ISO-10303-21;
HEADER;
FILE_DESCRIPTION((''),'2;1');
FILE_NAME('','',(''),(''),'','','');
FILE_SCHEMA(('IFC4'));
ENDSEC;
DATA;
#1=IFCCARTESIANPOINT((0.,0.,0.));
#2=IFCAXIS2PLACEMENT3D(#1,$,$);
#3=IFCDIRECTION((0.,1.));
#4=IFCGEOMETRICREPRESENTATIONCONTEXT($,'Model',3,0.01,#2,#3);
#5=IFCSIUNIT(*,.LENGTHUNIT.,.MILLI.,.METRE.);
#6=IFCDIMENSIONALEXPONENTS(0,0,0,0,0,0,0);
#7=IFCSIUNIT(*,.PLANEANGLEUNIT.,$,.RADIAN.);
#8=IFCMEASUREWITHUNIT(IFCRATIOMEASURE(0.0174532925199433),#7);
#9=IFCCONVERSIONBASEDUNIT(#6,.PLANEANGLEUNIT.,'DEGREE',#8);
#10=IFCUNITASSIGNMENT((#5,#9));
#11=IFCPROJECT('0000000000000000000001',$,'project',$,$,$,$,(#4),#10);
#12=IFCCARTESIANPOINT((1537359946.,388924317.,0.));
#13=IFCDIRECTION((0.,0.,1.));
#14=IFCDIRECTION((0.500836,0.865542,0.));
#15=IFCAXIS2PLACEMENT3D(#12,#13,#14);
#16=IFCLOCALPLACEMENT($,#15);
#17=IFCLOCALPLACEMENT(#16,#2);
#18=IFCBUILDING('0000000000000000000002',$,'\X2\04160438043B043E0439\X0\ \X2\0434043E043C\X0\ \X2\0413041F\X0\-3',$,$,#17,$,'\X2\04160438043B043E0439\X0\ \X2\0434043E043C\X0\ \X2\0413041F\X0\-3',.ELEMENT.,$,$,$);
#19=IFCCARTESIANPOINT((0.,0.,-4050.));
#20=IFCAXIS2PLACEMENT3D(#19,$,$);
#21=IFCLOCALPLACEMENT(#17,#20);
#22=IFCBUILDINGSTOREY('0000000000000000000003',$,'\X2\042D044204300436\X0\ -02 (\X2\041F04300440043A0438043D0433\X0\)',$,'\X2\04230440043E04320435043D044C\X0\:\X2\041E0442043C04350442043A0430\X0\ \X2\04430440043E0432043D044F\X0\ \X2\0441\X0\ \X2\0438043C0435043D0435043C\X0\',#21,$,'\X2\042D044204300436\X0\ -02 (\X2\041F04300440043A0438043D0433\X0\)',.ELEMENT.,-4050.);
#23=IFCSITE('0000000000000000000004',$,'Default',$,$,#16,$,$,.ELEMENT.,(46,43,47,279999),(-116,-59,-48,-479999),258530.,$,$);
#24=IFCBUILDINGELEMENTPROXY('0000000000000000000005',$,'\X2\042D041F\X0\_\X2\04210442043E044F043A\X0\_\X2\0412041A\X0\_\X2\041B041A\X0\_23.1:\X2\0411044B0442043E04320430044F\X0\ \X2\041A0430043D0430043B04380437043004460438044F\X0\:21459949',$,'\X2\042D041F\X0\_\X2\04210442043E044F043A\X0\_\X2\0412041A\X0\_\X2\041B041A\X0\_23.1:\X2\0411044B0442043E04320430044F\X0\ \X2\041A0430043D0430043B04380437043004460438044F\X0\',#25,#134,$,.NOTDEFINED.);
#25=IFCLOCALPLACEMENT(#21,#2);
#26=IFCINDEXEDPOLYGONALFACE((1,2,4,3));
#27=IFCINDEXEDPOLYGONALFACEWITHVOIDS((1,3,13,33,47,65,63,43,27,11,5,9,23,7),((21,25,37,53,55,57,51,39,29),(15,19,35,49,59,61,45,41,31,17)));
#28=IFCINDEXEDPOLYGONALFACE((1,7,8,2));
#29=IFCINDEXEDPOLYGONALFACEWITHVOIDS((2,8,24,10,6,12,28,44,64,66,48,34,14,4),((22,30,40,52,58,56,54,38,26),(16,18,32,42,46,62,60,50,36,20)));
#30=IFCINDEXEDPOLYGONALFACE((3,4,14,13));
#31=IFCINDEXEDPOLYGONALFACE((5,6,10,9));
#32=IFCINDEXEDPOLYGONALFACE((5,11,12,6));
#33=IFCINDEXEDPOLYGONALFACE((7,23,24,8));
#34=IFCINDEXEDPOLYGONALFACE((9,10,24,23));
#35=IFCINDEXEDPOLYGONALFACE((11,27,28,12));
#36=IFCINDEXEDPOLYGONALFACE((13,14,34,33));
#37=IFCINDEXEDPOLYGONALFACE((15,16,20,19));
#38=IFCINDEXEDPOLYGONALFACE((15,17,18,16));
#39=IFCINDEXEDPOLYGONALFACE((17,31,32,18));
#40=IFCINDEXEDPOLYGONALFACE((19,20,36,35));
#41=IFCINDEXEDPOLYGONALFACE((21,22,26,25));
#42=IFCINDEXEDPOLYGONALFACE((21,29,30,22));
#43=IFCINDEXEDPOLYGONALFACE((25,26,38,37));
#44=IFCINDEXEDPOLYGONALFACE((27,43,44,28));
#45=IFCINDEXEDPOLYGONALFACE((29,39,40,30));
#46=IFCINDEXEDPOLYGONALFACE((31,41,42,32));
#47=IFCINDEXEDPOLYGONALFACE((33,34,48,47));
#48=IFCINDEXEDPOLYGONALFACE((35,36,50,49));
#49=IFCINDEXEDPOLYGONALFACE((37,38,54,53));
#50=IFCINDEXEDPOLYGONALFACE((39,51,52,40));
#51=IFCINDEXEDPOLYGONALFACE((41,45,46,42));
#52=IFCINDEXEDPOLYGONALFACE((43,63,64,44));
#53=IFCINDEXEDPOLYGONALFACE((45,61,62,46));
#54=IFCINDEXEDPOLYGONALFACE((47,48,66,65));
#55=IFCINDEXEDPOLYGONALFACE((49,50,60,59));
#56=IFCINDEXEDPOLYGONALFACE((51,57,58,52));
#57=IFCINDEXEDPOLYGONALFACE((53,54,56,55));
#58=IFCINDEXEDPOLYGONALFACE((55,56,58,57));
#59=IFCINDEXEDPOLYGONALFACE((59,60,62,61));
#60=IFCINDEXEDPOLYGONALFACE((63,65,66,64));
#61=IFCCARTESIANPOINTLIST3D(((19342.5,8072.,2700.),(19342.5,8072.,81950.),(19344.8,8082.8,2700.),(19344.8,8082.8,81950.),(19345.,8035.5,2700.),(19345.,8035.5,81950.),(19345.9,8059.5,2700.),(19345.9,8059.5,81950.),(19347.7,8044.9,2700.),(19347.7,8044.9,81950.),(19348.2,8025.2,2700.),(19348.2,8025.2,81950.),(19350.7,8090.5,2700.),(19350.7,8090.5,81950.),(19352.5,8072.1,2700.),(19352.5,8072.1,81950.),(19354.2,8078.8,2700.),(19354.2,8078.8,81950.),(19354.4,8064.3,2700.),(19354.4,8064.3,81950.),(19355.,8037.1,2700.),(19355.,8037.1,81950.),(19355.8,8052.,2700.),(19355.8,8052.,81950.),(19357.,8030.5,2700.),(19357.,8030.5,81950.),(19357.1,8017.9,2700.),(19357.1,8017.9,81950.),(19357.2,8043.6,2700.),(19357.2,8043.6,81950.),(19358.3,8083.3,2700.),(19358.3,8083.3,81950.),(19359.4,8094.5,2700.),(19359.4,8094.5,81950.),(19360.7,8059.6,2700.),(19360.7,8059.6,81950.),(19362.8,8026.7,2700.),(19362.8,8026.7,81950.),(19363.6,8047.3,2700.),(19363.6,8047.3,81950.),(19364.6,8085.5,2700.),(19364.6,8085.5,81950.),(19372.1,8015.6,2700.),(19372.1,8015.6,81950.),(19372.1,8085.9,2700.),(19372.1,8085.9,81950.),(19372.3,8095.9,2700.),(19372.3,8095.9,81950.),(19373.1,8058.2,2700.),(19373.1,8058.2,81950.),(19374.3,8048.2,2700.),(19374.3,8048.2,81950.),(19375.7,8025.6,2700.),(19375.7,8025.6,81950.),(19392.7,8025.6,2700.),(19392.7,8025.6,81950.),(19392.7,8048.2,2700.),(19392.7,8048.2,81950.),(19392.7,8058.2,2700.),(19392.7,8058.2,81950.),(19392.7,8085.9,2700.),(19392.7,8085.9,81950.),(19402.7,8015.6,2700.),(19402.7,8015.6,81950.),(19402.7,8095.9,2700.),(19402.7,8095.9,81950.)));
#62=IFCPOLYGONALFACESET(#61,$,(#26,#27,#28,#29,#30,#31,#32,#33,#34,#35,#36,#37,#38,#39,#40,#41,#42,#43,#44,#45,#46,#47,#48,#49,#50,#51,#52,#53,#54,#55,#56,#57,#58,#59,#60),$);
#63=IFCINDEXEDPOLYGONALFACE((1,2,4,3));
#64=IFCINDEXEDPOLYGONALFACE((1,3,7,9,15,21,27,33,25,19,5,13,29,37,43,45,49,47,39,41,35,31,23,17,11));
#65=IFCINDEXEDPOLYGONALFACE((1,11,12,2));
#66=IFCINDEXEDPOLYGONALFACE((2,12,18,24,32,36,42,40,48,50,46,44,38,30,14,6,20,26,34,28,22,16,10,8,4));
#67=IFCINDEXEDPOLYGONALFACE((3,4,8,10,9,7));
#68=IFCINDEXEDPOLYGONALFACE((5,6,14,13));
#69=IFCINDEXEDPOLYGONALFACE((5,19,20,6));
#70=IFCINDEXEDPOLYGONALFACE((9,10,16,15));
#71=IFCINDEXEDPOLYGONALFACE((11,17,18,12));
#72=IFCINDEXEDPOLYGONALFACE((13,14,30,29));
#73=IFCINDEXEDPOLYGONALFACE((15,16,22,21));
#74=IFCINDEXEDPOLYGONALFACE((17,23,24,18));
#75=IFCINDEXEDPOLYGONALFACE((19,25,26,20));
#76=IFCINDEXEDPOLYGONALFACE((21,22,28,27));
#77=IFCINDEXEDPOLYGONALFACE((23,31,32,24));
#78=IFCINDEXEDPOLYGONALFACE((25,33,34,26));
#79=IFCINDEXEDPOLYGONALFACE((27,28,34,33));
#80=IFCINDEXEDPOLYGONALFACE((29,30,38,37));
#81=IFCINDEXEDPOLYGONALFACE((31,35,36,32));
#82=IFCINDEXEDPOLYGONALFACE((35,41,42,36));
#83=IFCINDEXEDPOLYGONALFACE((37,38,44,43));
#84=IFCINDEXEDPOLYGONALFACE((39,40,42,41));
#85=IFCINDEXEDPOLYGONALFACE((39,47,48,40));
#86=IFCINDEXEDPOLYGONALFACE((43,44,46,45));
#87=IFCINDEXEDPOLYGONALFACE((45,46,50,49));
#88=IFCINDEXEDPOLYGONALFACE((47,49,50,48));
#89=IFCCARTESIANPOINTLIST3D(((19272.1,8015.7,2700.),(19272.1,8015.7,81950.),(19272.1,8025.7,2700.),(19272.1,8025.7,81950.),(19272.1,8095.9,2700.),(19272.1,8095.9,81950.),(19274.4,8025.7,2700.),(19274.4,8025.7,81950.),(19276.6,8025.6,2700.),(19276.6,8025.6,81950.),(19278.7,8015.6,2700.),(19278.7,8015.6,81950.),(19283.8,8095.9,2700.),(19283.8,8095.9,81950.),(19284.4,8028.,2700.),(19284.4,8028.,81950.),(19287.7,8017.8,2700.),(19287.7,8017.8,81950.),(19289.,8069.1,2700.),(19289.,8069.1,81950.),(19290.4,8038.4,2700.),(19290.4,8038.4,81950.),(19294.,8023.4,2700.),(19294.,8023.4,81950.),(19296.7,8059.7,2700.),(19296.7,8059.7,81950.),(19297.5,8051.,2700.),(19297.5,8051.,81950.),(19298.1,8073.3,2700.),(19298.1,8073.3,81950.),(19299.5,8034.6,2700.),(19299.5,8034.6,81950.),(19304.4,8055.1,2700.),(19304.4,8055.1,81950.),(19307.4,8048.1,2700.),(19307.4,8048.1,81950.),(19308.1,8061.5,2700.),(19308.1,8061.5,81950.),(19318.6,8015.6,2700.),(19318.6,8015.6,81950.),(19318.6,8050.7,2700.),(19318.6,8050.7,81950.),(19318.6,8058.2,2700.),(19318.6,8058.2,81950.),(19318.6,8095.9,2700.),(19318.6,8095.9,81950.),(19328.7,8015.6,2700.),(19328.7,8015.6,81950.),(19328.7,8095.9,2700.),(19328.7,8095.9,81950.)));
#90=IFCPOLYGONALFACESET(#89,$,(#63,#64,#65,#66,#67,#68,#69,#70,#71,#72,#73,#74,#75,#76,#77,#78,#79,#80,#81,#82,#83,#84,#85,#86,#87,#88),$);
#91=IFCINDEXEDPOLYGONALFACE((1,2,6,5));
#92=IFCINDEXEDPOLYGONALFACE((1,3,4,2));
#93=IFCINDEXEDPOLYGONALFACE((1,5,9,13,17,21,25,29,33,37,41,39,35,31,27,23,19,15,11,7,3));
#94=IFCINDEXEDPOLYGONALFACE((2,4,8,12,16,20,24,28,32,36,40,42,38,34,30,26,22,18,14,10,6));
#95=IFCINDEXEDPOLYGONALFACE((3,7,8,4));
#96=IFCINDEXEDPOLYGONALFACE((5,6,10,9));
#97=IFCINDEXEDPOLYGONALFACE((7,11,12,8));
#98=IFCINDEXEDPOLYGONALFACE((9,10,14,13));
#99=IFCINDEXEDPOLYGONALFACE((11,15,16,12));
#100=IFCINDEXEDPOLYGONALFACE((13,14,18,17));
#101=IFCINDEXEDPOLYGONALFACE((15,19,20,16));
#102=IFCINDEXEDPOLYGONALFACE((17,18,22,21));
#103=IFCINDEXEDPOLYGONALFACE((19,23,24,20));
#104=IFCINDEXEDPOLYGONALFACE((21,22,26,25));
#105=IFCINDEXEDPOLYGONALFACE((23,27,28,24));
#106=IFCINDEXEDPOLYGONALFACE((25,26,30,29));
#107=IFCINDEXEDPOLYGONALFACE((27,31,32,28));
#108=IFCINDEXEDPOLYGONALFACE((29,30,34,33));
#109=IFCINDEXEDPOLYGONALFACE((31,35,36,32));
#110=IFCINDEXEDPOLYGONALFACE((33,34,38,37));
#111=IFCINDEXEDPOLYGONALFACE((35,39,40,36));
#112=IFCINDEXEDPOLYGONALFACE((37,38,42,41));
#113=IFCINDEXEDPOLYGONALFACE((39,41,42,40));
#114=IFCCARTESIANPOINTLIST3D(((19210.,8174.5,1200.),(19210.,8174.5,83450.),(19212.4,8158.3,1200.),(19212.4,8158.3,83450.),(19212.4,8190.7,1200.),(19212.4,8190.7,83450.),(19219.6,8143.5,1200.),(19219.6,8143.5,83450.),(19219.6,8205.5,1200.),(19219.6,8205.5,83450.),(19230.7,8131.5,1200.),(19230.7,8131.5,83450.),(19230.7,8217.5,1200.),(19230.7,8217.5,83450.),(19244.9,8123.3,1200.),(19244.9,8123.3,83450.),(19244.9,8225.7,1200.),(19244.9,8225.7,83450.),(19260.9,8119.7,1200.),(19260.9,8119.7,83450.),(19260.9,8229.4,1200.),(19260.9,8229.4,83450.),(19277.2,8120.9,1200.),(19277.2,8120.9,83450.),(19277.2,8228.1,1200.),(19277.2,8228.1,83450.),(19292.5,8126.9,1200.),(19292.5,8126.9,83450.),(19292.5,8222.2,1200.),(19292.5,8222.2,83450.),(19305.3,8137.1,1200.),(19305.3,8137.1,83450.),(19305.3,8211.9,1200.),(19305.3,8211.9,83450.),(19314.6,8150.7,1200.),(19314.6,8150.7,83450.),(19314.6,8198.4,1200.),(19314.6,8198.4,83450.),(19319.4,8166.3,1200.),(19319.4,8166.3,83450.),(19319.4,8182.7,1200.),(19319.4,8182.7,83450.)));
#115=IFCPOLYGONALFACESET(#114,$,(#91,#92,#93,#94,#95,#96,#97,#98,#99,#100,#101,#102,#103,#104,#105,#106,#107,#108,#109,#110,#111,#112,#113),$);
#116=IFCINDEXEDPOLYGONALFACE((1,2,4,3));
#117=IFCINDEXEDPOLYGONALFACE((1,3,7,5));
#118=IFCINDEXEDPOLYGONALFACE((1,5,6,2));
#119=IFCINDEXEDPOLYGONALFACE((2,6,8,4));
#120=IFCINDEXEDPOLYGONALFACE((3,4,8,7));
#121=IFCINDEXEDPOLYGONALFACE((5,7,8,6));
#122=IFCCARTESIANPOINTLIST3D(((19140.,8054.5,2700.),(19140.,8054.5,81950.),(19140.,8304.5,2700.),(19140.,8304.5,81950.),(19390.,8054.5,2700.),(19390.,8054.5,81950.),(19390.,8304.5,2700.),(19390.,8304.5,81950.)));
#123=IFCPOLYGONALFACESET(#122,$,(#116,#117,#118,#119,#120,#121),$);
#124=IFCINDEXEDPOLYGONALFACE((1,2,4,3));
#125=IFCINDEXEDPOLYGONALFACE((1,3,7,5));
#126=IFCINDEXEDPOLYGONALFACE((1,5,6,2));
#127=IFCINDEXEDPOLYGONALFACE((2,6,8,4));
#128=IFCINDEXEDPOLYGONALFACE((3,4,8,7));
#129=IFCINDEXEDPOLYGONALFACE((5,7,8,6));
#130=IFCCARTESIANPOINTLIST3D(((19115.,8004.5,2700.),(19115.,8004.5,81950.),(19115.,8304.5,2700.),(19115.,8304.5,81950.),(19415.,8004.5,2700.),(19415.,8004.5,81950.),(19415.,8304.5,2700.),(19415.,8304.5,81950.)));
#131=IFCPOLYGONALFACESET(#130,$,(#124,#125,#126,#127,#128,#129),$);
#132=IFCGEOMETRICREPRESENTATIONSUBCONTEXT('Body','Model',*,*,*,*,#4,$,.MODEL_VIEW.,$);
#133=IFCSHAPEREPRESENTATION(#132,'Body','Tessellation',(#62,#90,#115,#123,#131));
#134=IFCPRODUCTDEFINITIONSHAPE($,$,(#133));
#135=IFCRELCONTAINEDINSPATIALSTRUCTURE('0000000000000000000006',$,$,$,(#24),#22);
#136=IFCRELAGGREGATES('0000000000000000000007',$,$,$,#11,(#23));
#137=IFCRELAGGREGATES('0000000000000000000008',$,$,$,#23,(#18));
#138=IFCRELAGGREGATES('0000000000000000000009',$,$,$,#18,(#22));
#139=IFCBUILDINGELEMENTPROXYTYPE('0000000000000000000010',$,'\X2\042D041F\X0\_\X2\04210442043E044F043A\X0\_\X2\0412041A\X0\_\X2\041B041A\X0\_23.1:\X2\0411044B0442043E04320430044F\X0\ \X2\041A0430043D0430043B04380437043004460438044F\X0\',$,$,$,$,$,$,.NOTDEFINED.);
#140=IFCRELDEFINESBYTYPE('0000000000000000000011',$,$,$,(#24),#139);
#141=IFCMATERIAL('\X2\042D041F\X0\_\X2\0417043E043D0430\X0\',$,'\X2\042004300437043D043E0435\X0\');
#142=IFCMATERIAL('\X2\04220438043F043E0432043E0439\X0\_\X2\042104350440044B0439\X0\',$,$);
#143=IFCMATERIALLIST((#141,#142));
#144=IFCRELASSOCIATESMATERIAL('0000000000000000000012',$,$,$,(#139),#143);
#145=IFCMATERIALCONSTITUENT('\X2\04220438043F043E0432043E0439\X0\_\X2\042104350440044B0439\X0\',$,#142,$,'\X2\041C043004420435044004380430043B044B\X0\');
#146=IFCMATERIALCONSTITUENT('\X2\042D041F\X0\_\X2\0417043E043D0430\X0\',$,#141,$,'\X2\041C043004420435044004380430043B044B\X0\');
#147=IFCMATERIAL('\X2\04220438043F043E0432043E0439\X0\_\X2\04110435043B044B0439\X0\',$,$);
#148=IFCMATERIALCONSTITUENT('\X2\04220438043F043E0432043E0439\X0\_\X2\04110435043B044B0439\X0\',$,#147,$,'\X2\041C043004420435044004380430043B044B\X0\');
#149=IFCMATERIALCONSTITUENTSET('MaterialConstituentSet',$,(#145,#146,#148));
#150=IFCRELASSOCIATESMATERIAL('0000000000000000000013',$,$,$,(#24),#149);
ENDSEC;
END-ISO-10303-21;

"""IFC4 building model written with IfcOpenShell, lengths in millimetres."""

from ifc_helpers import new_model, entity, si_unit, converted_unit, direction, frame, frame_2d, origin, place, context, subcontext, project, spatial, polyline, rectangle, circle, outline, extrude, source, transform, mapped, material, material_list, constituent, constituent_set, type_object, type_shapes, element, save


model = new_model("IFC4")

# Units and contexts
model_context = context("Model", 3, precision=0.01, world=origin(), true_north=direction((0.0, 1.0)))
body_context = subcontext(model_context, "Body", "Model", "MODEL_VIEW")
ifc_project = project(units=[si_unit("LENGTHUNIT", "METRE", prefix="MILLI"), converted_unit("PLANEANGLEUNIT", "DEGREE", entity("IfcRatioMeasure", 0.0174532925199433), si_unit("PLANEANGLEUNIT", "RADIAN"), dimensions=[0, 0, 0, 0, 0, 0, 0])], contexts=[model_context])

# Site, building, storey
site_placement = place(None, frame((1537359946.0, 388924317.0, 0.0), z_axis=(0.0, 0.0, 1.0), x_axis=(0.500836, 0.865542, 0.0)))
site = spatial("IfcSite", under=ifc_project, at=site_placement, Name="Default", CompositionType="ELEMENT", RefLatitude=(46, 43, 47, 279999), RefLongitude=(-116, -59, -48, -479999), RefElevation=258530.0)
building_placement = place(site_placement, origin())
building = spatial("IfcBuilding", under=site, at=building_placement, Name="Жилой дом ГП-3", LongName="Жилой дом ГП-3", CompositionType="ELEMENT")
storey_placement = place(building_placement, frame((0.0, 0.0, -4050.0)))
storey = spatial("IfcBuildingStorey", under=building, at=storey_placement, Name="Этаж -02 (Паркинг)", ObjectType="Уровень:Отметка уровня с именем", LongName="Этаж -02 (Паркинг)", CompositionType="ELEMENT", Elevation=-4050.0)

# Building element proxy
ifc_material_1 = material(Name="Типовой_Серый")
ifc_material_2 = material(Name="ЭП_Зона", Category="Разное")
ifc_material_3 = material(Name="Типовой_Белый")
ifc_constituent_1 = constituent(ifc_material_1, Name="Типовой_Серый", Category="Материалы")
ifc_constituent_2 = constituent(ifc_material_2, Name="ЭП_Зона", Category="Материалы")
ifc_constituent_3 = constituent(ifc_material_3, Name="Типовой_Белый", Category="Материалы")
ifc_constituent_set_1 = constituent_set(constituents=[ifc_constituent_1, ifc_constituent_2, ifc_constituent_3], Name="MaterialConstituentSet")
ifc_material_list_1 = material_list([ifc_material_2, ifc_material_1])
building_element_proxy_type_1 = type_object("IfcBuildingElementProxyType", Name="ЭП_Стояк_ВК_ЛК_23.1:Бытовая Канализация", PredefinedType="NOTDEFINED", material=ifc_material_list_1)
shared_shape_1 = source(origin(), body_context, "Body", "SweptSolid", [
    extrude(outline(polyline([(-42.2, -39.0), (-11.8, -39.0), (1.1, -37.6), (9.8, -33.5), (15.7, -25.8), (18.0, -15.0), (14.6, -2.5), (4.7, 5.0), (12.8, 12.1), (15.5, 21.5), (12.3, 31.8), (3.4, 39.0), (-11.6, 41.4), (-42.2, 41.4), (-42.2, -39.0)]), holes=[polyline([(-32.2, 8.8), (-32.2, 31.4), (-15.2, 31.4), (-2.3, 30.3), (3.5, 26.4), (5.5, 19.9), (3.3, 13.3), (-3.1, 9.6), (-13.9, 8.8), (-32.2, 8.8)]), polyline([(-32.2, -28.9), (-32.2, -1.3), (-12.6, -1.3), (-0.2, -2.6), (6.1, -7.3), (8.0, -15.1), (6.3, -21.9), (2.2, -26.3), (-4.1, -28.5), (-11.6, -28.9), (-32.2, -28.9)])]), frame((54.5, -52.4, -1350.0)), (0.0, 0.0, 1.0), 79250.0),
    extrude(outline(polyline([(-32.1, -31.9), (48.3, -31.9), (48.3, -21.8), (10.6, -21.8), (13.8, -11.4), (25.6, -1.3), (48.3, 13.0), (48.3, 24.6), (21.4, 7.7), (12.0, 0.1), (7.4, -7.7), (3.3, -0.7), (-9.3, 6.4), (-19.7, 12.3), (-22.1, 20.2), (-22.0, 22.4), (-22.0, 24.6), (-32.0, 24.6), (-32.1, 18.0), (-29.9, 9.0), (-24.3, 2.8), (-13.1, -2.8), (0.4, -10.6), (3.0, -21.8), (-32.1, -21.8), (-32.1, -31.9)])), frame((118.2, -43.1, -1350.0), z_axis=(0.0, 0.0, 1.0), x_axis=(0.0, -1.0, 0.0)), (0.0, 0.0, 1.0), 79250.0),
    extrude(circle(Radius=55.0, at=frame_2d((0.0, 0.0), x_axis=(1.0, 0.0))), frame((150.0, -170.0, -2850.0)), (0.0, 0.0, 1.0), 82250.0),
    extrude(rectangle(XDim=250.0, YDim=250.0, at=frame_2d((0.0, 0.0), x_axis=(1.0, 0.0))), frame((150.0, -175.0, -1350.0)), (0.0, 0.0, 1.0), 79250.0),
    extrude(rectangle(XDim=300.0, YDim=300.0, at=frame_2d((0.0, 0.0), x_axis=(1.0, 0.0))), frame((150.0, -150.0, -1350.0)), (0.0, 0.0, 1.0), 79250.0),
])
type_shapes(building_element_proxy_type_1, [shared_shape_1])
proxy_1_placement = place(storey_placement, frame((19415.0, 8004.5, 4050.0), z_axis=(0.0, 0.0, 1.0), x_axis=(-1.0, 0.0, 0.0)))
element("IfcBuildingElementProxy", 1, at=proxy_1_placement, inside=storey, type_object=building_element_proxy_type_1, material=ifc_constituent_set_1, Name="ЭП_Стояк_ВК_ЛК_23.1:Бытовая Канализация:21459949", ObjectType="ЭП_Стояк_ВК_ЛК_23.1:Бытовая Канализация", PredefinedType="NOTDEFINED", context=body_context, shape_type="MappedRepresentation", body=[
    mapped(shared_shape_1, transform((0.0, 0.0, 0.0), scale=1.0)),
])

save(model, "model.ifc")
